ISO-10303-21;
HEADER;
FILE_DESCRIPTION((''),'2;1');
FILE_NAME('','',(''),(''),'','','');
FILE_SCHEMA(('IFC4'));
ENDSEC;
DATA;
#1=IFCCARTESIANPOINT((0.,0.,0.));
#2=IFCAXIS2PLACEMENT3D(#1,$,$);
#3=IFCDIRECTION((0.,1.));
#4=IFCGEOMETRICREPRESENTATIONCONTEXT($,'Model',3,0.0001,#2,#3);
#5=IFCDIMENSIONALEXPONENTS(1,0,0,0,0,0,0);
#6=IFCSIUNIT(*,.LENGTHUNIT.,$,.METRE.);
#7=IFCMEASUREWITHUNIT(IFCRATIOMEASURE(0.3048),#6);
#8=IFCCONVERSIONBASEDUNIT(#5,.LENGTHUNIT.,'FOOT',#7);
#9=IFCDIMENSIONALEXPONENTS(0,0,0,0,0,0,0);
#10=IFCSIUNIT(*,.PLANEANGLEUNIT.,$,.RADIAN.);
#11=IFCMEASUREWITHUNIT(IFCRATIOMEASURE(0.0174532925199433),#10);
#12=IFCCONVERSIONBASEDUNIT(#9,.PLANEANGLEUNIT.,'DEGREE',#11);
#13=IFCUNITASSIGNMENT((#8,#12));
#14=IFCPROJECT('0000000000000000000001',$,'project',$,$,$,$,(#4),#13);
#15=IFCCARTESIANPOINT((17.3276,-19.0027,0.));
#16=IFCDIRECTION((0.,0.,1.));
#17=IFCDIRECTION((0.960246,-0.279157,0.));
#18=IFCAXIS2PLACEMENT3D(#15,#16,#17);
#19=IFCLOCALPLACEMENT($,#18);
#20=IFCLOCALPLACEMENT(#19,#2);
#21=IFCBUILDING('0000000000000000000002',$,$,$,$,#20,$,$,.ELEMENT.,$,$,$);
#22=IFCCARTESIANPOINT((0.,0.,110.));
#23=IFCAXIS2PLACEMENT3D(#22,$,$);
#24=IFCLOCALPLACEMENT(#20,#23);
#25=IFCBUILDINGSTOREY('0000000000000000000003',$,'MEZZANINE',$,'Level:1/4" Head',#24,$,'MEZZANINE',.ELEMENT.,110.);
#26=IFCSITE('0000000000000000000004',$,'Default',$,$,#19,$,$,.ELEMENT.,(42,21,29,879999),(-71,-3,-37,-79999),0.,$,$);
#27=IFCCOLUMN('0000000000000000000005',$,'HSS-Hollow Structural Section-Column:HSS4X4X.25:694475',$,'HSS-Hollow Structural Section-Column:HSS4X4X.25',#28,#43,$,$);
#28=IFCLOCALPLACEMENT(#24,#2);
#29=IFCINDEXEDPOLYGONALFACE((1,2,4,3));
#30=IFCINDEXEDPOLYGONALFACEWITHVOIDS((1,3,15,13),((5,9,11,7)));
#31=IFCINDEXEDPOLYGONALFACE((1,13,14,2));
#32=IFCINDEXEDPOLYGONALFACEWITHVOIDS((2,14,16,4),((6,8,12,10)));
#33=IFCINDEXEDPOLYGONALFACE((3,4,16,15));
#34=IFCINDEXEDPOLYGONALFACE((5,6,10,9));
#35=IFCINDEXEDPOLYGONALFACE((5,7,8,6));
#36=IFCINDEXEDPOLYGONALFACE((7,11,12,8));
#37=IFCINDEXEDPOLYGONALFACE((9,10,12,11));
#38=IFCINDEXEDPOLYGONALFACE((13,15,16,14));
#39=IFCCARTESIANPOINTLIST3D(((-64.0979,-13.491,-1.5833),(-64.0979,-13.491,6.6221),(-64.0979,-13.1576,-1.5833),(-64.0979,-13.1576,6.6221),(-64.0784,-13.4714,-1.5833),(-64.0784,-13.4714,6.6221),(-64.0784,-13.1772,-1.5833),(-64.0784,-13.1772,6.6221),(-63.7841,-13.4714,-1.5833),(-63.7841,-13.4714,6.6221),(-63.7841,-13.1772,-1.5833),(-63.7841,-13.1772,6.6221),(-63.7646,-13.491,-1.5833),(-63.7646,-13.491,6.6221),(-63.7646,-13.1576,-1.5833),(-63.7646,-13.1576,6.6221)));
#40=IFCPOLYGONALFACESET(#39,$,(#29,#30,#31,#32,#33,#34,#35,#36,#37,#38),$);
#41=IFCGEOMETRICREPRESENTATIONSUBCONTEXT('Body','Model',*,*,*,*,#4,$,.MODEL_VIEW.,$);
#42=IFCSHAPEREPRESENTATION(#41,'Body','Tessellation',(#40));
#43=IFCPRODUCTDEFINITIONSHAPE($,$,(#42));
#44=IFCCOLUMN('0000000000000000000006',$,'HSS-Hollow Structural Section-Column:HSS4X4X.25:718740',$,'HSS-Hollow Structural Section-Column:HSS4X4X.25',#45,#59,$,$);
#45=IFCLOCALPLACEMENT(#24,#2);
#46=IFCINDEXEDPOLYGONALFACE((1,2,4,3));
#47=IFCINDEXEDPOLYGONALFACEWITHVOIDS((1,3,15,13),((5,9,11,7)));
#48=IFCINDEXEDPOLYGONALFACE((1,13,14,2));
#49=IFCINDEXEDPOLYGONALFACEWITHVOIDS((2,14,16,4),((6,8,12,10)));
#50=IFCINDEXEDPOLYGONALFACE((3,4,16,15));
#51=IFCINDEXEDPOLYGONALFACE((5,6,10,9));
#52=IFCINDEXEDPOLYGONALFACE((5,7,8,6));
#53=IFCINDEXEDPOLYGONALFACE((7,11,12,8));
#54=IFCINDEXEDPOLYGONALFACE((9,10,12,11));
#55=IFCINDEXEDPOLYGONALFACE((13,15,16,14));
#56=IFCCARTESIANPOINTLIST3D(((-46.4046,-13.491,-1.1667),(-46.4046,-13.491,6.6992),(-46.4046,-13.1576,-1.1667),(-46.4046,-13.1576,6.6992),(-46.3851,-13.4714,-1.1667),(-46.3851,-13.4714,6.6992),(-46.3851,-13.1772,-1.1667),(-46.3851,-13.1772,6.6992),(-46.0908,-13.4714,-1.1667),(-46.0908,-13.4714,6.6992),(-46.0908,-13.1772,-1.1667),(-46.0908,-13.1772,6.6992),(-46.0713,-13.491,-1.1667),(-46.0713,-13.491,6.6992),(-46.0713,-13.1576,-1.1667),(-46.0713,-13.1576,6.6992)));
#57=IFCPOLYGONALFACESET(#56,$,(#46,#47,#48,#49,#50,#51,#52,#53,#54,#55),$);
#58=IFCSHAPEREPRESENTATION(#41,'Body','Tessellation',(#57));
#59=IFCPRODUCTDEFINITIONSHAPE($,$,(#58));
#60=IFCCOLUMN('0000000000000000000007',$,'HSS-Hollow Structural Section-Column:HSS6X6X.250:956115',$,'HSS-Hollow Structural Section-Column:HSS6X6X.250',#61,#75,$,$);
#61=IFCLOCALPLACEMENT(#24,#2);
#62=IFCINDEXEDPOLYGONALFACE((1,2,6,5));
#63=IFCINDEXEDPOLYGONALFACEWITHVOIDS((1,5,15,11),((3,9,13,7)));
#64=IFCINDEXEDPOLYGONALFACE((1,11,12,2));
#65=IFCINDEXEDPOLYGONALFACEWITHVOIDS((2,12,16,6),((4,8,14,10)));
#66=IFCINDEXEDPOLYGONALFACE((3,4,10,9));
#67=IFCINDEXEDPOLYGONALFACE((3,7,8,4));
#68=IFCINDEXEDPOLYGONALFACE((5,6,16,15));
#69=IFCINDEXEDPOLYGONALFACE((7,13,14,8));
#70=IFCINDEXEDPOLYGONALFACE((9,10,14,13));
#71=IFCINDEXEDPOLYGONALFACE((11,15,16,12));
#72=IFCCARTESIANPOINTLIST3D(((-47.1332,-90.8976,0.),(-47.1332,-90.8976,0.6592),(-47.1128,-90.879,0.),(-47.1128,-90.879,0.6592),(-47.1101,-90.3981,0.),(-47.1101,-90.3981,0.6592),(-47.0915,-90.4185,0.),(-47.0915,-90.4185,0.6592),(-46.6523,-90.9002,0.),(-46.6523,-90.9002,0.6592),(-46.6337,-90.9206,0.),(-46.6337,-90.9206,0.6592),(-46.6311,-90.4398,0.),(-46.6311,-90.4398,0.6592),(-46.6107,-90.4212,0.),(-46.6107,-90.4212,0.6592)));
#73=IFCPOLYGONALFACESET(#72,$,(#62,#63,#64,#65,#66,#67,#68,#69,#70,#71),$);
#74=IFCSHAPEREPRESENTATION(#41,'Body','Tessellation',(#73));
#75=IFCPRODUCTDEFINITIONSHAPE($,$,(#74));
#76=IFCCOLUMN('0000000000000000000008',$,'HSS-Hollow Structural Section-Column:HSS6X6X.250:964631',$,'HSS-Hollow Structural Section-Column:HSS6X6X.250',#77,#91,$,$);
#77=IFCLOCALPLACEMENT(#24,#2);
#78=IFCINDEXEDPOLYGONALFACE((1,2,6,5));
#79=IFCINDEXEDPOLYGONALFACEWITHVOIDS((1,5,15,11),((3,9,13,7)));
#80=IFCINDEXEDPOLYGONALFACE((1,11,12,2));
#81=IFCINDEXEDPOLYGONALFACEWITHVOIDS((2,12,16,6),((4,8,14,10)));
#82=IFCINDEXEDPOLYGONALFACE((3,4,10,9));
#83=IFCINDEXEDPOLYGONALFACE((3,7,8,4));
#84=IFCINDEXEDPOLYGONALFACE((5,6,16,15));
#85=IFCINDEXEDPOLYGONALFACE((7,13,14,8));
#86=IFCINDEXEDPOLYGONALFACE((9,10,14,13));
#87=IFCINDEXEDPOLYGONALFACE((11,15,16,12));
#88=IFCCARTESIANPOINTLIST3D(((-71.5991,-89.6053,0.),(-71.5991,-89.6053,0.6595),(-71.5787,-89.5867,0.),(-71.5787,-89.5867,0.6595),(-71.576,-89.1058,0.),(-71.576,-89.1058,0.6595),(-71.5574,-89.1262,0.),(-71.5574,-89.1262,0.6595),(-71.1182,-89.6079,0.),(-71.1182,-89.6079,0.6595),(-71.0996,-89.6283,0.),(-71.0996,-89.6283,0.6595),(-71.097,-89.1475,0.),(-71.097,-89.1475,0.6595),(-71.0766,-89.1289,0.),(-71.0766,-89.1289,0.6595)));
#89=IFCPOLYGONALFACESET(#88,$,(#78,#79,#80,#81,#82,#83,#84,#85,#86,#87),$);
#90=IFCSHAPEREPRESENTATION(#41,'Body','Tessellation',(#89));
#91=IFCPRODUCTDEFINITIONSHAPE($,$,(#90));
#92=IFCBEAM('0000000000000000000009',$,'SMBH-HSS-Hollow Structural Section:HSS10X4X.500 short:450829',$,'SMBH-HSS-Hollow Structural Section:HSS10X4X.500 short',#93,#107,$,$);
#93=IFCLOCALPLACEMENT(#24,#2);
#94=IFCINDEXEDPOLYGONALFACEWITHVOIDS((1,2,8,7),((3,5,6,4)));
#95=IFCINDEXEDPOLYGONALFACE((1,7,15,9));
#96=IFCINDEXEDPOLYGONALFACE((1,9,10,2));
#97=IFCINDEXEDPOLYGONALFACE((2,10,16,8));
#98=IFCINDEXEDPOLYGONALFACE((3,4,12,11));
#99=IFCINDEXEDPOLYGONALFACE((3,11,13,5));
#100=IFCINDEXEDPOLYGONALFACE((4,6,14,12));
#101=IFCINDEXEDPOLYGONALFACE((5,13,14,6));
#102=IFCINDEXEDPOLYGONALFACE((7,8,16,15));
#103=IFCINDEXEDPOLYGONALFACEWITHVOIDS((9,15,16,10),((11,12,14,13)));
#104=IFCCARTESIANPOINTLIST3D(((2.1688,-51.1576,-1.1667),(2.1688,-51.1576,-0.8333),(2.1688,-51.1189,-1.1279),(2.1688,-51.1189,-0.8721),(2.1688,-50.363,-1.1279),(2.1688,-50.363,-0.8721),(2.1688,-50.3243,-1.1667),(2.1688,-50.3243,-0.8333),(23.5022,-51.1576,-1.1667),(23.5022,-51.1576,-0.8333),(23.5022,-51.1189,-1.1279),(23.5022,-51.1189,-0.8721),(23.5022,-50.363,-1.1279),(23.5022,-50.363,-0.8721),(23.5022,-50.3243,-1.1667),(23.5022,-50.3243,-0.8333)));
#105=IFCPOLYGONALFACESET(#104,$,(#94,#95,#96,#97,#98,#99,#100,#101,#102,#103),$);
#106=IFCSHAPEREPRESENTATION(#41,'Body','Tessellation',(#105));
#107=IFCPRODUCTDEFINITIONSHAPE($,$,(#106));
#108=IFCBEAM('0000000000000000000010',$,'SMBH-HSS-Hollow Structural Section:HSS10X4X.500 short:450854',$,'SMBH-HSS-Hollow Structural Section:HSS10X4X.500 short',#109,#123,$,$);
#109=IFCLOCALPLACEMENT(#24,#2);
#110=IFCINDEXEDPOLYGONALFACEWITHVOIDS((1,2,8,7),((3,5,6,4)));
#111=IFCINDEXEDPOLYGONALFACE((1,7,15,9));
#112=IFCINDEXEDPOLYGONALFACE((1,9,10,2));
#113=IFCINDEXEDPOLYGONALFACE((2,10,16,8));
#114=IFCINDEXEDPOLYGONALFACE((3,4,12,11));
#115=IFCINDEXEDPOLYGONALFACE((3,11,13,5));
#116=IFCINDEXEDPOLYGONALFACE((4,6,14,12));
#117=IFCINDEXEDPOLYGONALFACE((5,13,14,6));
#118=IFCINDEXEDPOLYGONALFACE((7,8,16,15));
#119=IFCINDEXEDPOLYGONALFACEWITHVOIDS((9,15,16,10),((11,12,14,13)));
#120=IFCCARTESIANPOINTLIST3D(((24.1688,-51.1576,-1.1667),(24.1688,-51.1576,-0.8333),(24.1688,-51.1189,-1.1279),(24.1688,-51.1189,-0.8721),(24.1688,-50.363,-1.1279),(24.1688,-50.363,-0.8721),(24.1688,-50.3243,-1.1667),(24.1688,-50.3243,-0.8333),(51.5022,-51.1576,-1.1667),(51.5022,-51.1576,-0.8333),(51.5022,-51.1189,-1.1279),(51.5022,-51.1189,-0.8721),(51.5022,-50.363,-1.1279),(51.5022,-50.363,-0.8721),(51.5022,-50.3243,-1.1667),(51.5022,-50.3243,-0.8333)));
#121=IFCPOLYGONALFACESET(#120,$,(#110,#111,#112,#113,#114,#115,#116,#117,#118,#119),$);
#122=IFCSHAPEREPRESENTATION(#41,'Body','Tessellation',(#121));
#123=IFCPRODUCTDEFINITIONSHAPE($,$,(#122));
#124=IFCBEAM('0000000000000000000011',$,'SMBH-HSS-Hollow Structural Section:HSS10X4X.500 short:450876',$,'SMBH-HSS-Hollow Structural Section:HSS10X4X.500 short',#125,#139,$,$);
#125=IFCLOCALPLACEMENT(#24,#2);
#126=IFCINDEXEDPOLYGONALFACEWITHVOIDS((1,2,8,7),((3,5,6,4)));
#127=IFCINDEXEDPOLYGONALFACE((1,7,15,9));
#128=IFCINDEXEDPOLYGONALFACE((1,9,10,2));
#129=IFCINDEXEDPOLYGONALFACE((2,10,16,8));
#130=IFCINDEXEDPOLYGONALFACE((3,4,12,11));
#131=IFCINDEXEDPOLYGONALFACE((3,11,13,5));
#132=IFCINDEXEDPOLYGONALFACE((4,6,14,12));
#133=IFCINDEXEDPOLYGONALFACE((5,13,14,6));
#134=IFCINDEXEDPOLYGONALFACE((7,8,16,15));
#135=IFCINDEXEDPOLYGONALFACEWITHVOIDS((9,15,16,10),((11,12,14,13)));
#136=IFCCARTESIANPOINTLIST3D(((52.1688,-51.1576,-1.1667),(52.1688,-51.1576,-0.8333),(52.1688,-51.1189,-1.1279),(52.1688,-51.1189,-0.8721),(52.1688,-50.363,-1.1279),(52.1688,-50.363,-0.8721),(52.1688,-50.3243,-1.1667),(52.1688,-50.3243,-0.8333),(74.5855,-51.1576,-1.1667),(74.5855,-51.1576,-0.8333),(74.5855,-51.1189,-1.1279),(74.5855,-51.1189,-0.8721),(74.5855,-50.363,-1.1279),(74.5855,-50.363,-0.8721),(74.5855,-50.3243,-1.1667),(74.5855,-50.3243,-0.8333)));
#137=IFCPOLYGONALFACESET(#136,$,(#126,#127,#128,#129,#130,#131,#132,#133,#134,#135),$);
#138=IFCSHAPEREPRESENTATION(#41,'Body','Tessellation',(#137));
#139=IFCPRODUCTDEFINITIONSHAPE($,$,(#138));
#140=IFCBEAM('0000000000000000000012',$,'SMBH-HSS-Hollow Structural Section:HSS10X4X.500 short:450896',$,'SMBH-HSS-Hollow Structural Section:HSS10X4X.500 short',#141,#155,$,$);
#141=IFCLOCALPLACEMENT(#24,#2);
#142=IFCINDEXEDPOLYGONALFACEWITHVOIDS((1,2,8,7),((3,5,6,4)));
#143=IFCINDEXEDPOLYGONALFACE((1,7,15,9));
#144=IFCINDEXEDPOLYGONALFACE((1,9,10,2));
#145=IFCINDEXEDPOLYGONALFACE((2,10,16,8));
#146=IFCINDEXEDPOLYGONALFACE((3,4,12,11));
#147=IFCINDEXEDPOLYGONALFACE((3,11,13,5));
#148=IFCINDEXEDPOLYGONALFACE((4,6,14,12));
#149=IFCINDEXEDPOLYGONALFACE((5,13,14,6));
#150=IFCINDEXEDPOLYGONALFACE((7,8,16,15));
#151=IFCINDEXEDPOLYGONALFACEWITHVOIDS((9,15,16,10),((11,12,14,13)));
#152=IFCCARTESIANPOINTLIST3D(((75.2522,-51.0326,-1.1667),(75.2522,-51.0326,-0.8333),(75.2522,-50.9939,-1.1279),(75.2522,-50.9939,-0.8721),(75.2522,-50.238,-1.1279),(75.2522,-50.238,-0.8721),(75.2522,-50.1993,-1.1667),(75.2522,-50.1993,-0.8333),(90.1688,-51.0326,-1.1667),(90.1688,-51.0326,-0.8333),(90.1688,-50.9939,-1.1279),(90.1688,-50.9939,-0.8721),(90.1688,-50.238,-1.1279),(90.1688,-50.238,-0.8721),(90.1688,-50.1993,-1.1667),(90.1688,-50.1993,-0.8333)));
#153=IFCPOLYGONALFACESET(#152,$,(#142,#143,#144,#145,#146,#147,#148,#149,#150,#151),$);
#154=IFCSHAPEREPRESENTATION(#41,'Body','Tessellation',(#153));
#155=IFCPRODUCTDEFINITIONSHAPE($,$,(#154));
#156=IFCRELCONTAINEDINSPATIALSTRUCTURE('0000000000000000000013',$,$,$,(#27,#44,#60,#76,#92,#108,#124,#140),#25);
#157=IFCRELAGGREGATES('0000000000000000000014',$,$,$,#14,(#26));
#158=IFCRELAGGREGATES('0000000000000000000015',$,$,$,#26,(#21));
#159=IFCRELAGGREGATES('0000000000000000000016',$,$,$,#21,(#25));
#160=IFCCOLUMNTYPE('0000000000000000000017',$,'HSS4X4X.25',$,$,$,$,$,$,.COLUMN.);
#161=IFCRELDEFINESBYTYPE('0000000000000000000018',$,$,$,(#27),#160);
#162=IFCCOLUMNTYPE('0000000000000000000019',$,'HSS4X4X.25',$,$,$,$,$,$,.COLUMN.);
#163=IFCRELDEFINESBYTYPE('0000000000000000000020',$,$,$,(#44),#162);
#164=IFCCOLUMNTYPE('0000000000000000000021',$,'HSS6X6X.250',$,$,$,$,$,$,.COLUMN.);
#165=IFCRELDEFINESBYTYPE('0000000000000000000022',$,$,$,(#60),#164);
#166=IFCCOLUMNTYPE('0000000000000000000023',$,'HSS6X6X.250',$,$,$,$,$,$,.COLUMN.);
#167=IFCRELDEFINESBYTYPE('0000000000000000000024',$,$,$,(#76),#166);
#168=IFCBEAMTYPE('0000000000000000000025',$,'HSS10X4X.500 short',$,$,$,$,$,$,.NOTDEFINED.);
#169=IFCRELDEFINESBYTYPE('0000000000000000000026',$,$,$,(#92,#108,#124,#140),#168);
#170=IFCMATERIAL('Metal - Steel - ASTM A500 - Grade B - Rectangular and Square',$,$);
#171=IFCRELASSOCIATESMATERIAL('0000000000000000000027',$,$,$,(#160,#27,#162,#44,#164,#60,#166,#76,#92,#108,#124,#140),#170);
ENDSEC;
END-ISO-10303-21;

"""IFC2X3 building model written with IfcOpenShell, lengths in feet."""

from ifc_helpers import new_model, entity, si_unit, converted_unit, direction, frame, frame_2d, origin, origin_2d_with_axis, place, context, subcontext, project, spatial, rectangle, extrude, boolean, source, transform, mapped, material, type_object, type_shapes, element, save


model = new_model("IFC2X3")

# Units and contexts
model_context = context("Model", 3, precision=0.0001, world=origin(), true_north=direction((0.0, 1.0)))
body_context = subcontext(model_context, "Body", "Model", "MODEL_VIEW")
ifc_project = project(units=[converted_unit("LENGTHUNIT", "FOOT", entity("IfcRatioMeasure", 0.3048), si_unit("LENGTHUNIT", "METRE"), dimensions=[1, 0, 0, 0, 0, 0, 0]), converted_unit("PLANEANGLEUNIT", "DEGREE", entity("IfcRatioMeasure", 0.0174532925199433), si_unit("PLANEANGLEUNIT", "RADIAN"), dimensions=[0, 0, 0, 0, 0, 0, 0])], contexts=[model_context])

# Site, building, storey
site_placement = place(None, frame((17.3276, -19.0027, 0.0), z_axis=(0.0, 0.0, 1.0), x_axis=(0.960246, -0.279157, 0.0)))
site = spatial("IfcSite", under=ifc_project, at=site_placement, Name="Default", CompositionType="ELEMENT", RefLatitude=(42, 21, 29, 879999), RefLongitude=(-71, -3, -37, -79999), RefElevation=0.0)
building_placement = place(site_placement, origin())
building = spatial("IfcBuilding", under=site, at=building_placement, CompositionType="ELEMENT")
storey_placement = place(building_placement, frame((0.0, 0.0, 110.0)))
storey = spatial("IfcBuildingStorey", under=building, at=storey_placement, Name="MEZZANINE", ObjectType="Level:1/4\" Head", LongName="MEZZANINE", CompositionType="ELEMENT", Elevation=110.0)

# Columns
ifc_material_1 = material(Name="Metal - Steel - ASTM A500 - Grade B - Rectangular and Square")
column_type_1 = type_object("IfcColumnType", Name="HSS4X4X.25", PredefinedType="COLUMN", material=ifc_material_1)
shared_shape_1 = source(origin(), body_context, "Body", "SweptSolid", [
    boolean("DIFFERENCE", extrude(rectangle(XDim=0.3333, YDim=0.3333, at=frame_2d((0.0, 0.0), x_axis=(1.0, 0.0))), frame((-63.9312, -13.3243, 108.4167), z_axis=(0.0, 0.0, 1.0), x_axis=(0.0, -1.0, 0.0)), (0.0, 0.0, 1.0), 8.2054), extrude(rectangle(XDim=0.2943, YDim=0.2943, at=frame_2d((0.0, 0.0), x_axis=(1.0, 0.0))), frame((-63.9312, -13.3243, 116.6221), z_axis=(0.0, 0.0, -1.0), x_axis=(0.0, -1.0, 0.0)), (0.0, 0.0, 1.0), 8.2054)),
])
type_shapes(column_type_1, [shared_shape_1])
column_1_placement = place(storey_placement, frame((0.0, 0.0, -110.0)))
element("IfcColumn", 1, at=column_1_placement, inside=storey, type_object=column_type_1, material=ifc_material_1, Name="HSS-Hollow Structural Section-Column:HSS4X4X.25:694475", ObjectType="HSS-Hollow Structural Section-Column:HSS4X4X.25", context=body_context, shape_type="MappedRepresentation", body=[
    mapped(shared_shape_1, transform((0.0, 0.0, 0.0), scale=1.0)),
])
column_type_2 = type_object("IfcColumnType", Name="HSS4X4X.25", PredefinedType="COLUMN", material=ifc_material_1)
shared_shape_2 = source(origin(), body_context, "Body", "SweptSolid", [
    boolean("DIFFERENCE", extrude(rectangle(XDim=0.3333, YDim=0.3333, at=origin_2d_with_axis()), frame((-46.2379, -13.3243, 108.8333), z_axis=(0.0, 0.0, 1.0), x_axis=(0.0, -1.0, 0.0)), (0.0, 0.0, 1.0), 7.8659), extrude(rectangle(XDim=0.2943, YDim=0.2943, at=frame_2d((0.0, 0.0), x_axis=(1.0, 0.0))), frame((-46.2379, -13.3243, 116.6992), z_axis=(0.0, 0.0, -1.0), x_axis=(0.0, -1.0, 0.0)), (0.0, 0.0, 1.0), 7.8659)),
])
type_shapes(column_type_2, [shared_shape_2])
column_2_placement = place(storey_placement, frame((0.0, 0.0, -110.0)))
element("IfcColumn", 2, at=column_2_placement, inside=storey, type_object=column_type_2, material=ifc_material_1, Name="HSS-Hollow Structural Section-Column:HSS4X4X.25:718740", ObjectType="HSS-Hollow Structural Section-Column:HSS4X4X.25", context=body_context, shape_type="MappedRepresentation", body=[
    mapped(shared_shape_2, transform((0.0, 0.0, 0.0), scale=1.0)),
])
column_type_3 = type_object("IfcColumnType", Name="HSS6X6X.250", PredefinedType="COLUMN", material=ifc_material_1)
shared_shape_3 = source(origin(), body_context, "Body", "SweptSolid", [
    boolean("DIFFERENCE", extrude(rectangle(XDim=0.5, YDim=0.5, at=origin_2d_with_axis()), frame((-46.8719, -90.6594, 110.0), z_axis=(0.0, 0.0, 1.0), x_axis=(0.0461, 0.998937, 0.0)), (0.0, 0.0, 1.0), 0.6592), extrude(rectangle(XDim=0.4609, YDim=0.4609, at=frame_2d((0.0, 0.0), x_axis=(1.0, 0.0))), frame((-46.8719, -90.6594, 110.6592), z_axis=(0.0, 0.0, -1.0), x_axis=(-0.0461, -0.998937, 0.0)), (0.0, 0.0, 1.0), 0.6592)),
])
type_shapes(column_type_3, [shared_shape_3])
column_3_placement = place(storey_placement, frame((0.0, 0.0, -110.0)))
element("IfcColumn", 3, at=column_3_placement, inside=storey, type_object=column_type_3, material=ifc_material_1, Name="HSS-Hollow Structural Section-Column:HSS6X6X.250:956115", ObjectType="HSS-Hollow Structural Section-Column:HSS6X6X.250", context=body_context, shape_type="MappedRepresentation", body=[
    mapped(shared_shape_3, transform((0.0, 0.0, 0.0), scale=1.0)),
])
column_type_4 = type_object("IfcColumnType", Name="HSS6X6X.250", PredefinedType="COLUMN", material=ifc_material_1)
shared_shape_4 = source(origin(), body_context, "Body", "SweptSolid", [
    boolean("DIFFERENCE", extrude(rectangle(XDim=0.5, YDim=0.5, at=origin_2d_with_axis()), frame((-71.3378, -89.3671, 110.0), z_axis=(0.0, 0.0, 1.0), x_axis=(0.0461, 0.998937, 0.0)), (0.0, 0.0, 1.0), 0.6595), extrude(rectangle(XDim=0.4609, YDim=0.4609, at=origin_2d_with_axis()), frame((-71.3378, -89.3671, 110.6595), z_axis=(0.0, 0.0, -1.0), x_axis=(-0.0461, -0.998937, 0.0)), (0.0, 0.0, 1.0), 0.6595)),
])
type_shapes(column_type_4, [shared_shape_4])
column_4_placement = place(storey_placement, frame((0.0, 0.0, -110.0)))
element("IfcColumn", 4, at=column_4_placement, inside=storey, type_object=column_type_4, material=ifc_material_1, Name="HSS-Hollow Structural Section-Column:HSS6X6X.250:964631", ObjectType="HSS-Hollow Structural Section-Column:HSS6X6X.250", context=body_context, shape_type="MappedRepresentation", body=[
    mapped(shared_shape_4, transform((0.0, 0.0, 0.0), scale=1.0)),
])

# Beams
beam_type_1 = type_object("IfcBeamType", Name="HSS10X4X.500 short", PredefinedType="NOTDEFINED")
beam_1_placement = place(storey_placement, frame((23.8355, -50.741, -0.8333), z_axis=(0.0, 0.0, 1.0), x_axis=(-1.0, 0.0, 0.0)))
element("IfcBeam", 5, at=beam_1_placement, inside=storey, type_object=beam_type_1, material=ifc_material_1, Name="SMBH-HSS-Hollow Structural Section:HSS10X4X.500 short:450829", ObjectType="SMBH-HSS-Hollow Structural Section:HSS10X4X.500 short", context=body_context, shape_type="SweptSolid", body=[
    boolean("DIFFERENCE", extrude(rectangle(XDim=0.3333, YDim=0.8333, at=frame_2d((0.0, 0.0), x_axis=(1.0, 0.0))), frame((0.3333, 0.0, -0.1667), z_axis=(1.0, 0.0, 0.0), x_axis=(0.0, 0.0, -1.0)), (0.0, 0.0, 1.0), 21.3333), extrude(rectangle(XDim=0.2559, YDim=0.7559, at=frame_2d((0.0, 0.0), x_axis=(0.0, 1.0))), frame((21.6667, 0.0, -0.1667), z_axis=(-1.0, 0.0, 0.0), x_axis=(0.0, 1.0, 0.0)), (0.0, 0.0, 1.0), 21.3333)),
])
beam_2_placement = place(storey_placement, frame((23.8355, -50.741, -0.8333)))
element("IfcBeam", 6, at=beam_2_placement, inside=storey, type_object=beam_type_1, material=ifc_material_1, Name="SMBH-HSS-Hollow Structural Section:HSS10X4X.500 short:450854", ObjectType="SMBH-HSS-Hollow Structural Section:HSS10X4X.500 short", context=body_context, shape_type="SweptSolid", body=[
    boolean("DIFFERENCE", extrude(rectangle(XDim=0.3333, YDim=0.8333, at=frame_2d((0.0, 0.0), x_axis=(1.0, 0.0))), frame((0.3333, 0.0, -0.1667), z_axis=(1.0, 0.0, 0.0), x_axis=(0.0, 0.0, -1.0)), (0.0, 0.0, 1.0), 27.3333), extrude(rectangle(XDim=0.2559, YDim=0.7559, at=frame_2d((0.0, 0.0), x_axis=(0.0, 1.0))), frame((27.6667, 0.0, -0.1667), z_axis=(-1.0, 0.0, 0.0), x_axis=(0.0, 1.0, 0.0)), (0.0, 0.0, 1.0), 27.3333)),
])
beam_3_placement = place(storey_placement, frame((51.8355, -50.741, -0.8333)))
element("IfcBeam", 7, at=beam_3_placement, inside=storey, type_object=beam_type_1, material=ifc_material_1, Name="SMBH-HSS-Hollow Structural Section:HSS10X4X.500 short:450876", ObjectType="SMBH-HSS-Hollow Structural Section:HSS10X4X.500 short", context=body_context, shape_type="SweptSolid", body=[
    boolean("DIFFERENCE", extrude(rectangle(XDim=0.3333, YDim=0.8333, at=frame_2d((0.0, 0.0), x_axis=(1.0, 0.0))), frame((0.3333, 0.0, -0.1667), z_axis=(1.0, 0.0, 0.0), x_axis=(0.0, 0.0, -1.0)), (0.0, 0.0, 1.0), 22.4167), extrude(rectangle(XDim=0.2559, YDim=0.7559, at=frame_2d((0.0, 0.0), x_axis=(0.0, 1.0))), frame((22.75, 0.0, -0.1667), z_axis=(-1.0, 0.0, 0.0), x_axis=(0.0, 1.0, 0.0)), (0.0, 0.0, 1.0), 22.4167)),
])
beam_4_placement = place(storey_placement, frame((74.9188, -50.616, -0.8333)))
element("IfcBeam", 8, at=beam_4_placement, inside=storey, type_object=beam_type_1, material=ifc_material_1, Name="SMBH-HSS-Hollow Structural Section:HSS10X4X.500 short:450896", ObjectType="SMBH-HSS-Hollow Structural Section:HSS10X4X.500 short", context=body_context, shape_type="SweptSolid", body=[
    boolean("DIFFERENCE", extrude(rectangle(XDim=0.3333, YDim=0.8333, at=frame_2d((0.0, 0.0), x_axis=(1.0, 0.0))), frame((0.3333, 0.0, -0.1667), z_axis=(1.0, 0.0, 0.0), x_axis=(0.0, 0.0, -1.0)), (0.0, 0.0, 1.0), 14.9167), extrude(rectangle(XDim=0.2559, YDim=0.7559, at=frame_2d((0.0, 0.0), x_axis=(0.0, 1.0))), frame((15.25, 0.0, -0.1667), z_axis=(-1.0, 0.0, 0.0), x_axis=(0.0, 1.0, 0.0)), (0.0, 0.0, 1.0), 14.9167)),
])

save(model, "model.ifc")
